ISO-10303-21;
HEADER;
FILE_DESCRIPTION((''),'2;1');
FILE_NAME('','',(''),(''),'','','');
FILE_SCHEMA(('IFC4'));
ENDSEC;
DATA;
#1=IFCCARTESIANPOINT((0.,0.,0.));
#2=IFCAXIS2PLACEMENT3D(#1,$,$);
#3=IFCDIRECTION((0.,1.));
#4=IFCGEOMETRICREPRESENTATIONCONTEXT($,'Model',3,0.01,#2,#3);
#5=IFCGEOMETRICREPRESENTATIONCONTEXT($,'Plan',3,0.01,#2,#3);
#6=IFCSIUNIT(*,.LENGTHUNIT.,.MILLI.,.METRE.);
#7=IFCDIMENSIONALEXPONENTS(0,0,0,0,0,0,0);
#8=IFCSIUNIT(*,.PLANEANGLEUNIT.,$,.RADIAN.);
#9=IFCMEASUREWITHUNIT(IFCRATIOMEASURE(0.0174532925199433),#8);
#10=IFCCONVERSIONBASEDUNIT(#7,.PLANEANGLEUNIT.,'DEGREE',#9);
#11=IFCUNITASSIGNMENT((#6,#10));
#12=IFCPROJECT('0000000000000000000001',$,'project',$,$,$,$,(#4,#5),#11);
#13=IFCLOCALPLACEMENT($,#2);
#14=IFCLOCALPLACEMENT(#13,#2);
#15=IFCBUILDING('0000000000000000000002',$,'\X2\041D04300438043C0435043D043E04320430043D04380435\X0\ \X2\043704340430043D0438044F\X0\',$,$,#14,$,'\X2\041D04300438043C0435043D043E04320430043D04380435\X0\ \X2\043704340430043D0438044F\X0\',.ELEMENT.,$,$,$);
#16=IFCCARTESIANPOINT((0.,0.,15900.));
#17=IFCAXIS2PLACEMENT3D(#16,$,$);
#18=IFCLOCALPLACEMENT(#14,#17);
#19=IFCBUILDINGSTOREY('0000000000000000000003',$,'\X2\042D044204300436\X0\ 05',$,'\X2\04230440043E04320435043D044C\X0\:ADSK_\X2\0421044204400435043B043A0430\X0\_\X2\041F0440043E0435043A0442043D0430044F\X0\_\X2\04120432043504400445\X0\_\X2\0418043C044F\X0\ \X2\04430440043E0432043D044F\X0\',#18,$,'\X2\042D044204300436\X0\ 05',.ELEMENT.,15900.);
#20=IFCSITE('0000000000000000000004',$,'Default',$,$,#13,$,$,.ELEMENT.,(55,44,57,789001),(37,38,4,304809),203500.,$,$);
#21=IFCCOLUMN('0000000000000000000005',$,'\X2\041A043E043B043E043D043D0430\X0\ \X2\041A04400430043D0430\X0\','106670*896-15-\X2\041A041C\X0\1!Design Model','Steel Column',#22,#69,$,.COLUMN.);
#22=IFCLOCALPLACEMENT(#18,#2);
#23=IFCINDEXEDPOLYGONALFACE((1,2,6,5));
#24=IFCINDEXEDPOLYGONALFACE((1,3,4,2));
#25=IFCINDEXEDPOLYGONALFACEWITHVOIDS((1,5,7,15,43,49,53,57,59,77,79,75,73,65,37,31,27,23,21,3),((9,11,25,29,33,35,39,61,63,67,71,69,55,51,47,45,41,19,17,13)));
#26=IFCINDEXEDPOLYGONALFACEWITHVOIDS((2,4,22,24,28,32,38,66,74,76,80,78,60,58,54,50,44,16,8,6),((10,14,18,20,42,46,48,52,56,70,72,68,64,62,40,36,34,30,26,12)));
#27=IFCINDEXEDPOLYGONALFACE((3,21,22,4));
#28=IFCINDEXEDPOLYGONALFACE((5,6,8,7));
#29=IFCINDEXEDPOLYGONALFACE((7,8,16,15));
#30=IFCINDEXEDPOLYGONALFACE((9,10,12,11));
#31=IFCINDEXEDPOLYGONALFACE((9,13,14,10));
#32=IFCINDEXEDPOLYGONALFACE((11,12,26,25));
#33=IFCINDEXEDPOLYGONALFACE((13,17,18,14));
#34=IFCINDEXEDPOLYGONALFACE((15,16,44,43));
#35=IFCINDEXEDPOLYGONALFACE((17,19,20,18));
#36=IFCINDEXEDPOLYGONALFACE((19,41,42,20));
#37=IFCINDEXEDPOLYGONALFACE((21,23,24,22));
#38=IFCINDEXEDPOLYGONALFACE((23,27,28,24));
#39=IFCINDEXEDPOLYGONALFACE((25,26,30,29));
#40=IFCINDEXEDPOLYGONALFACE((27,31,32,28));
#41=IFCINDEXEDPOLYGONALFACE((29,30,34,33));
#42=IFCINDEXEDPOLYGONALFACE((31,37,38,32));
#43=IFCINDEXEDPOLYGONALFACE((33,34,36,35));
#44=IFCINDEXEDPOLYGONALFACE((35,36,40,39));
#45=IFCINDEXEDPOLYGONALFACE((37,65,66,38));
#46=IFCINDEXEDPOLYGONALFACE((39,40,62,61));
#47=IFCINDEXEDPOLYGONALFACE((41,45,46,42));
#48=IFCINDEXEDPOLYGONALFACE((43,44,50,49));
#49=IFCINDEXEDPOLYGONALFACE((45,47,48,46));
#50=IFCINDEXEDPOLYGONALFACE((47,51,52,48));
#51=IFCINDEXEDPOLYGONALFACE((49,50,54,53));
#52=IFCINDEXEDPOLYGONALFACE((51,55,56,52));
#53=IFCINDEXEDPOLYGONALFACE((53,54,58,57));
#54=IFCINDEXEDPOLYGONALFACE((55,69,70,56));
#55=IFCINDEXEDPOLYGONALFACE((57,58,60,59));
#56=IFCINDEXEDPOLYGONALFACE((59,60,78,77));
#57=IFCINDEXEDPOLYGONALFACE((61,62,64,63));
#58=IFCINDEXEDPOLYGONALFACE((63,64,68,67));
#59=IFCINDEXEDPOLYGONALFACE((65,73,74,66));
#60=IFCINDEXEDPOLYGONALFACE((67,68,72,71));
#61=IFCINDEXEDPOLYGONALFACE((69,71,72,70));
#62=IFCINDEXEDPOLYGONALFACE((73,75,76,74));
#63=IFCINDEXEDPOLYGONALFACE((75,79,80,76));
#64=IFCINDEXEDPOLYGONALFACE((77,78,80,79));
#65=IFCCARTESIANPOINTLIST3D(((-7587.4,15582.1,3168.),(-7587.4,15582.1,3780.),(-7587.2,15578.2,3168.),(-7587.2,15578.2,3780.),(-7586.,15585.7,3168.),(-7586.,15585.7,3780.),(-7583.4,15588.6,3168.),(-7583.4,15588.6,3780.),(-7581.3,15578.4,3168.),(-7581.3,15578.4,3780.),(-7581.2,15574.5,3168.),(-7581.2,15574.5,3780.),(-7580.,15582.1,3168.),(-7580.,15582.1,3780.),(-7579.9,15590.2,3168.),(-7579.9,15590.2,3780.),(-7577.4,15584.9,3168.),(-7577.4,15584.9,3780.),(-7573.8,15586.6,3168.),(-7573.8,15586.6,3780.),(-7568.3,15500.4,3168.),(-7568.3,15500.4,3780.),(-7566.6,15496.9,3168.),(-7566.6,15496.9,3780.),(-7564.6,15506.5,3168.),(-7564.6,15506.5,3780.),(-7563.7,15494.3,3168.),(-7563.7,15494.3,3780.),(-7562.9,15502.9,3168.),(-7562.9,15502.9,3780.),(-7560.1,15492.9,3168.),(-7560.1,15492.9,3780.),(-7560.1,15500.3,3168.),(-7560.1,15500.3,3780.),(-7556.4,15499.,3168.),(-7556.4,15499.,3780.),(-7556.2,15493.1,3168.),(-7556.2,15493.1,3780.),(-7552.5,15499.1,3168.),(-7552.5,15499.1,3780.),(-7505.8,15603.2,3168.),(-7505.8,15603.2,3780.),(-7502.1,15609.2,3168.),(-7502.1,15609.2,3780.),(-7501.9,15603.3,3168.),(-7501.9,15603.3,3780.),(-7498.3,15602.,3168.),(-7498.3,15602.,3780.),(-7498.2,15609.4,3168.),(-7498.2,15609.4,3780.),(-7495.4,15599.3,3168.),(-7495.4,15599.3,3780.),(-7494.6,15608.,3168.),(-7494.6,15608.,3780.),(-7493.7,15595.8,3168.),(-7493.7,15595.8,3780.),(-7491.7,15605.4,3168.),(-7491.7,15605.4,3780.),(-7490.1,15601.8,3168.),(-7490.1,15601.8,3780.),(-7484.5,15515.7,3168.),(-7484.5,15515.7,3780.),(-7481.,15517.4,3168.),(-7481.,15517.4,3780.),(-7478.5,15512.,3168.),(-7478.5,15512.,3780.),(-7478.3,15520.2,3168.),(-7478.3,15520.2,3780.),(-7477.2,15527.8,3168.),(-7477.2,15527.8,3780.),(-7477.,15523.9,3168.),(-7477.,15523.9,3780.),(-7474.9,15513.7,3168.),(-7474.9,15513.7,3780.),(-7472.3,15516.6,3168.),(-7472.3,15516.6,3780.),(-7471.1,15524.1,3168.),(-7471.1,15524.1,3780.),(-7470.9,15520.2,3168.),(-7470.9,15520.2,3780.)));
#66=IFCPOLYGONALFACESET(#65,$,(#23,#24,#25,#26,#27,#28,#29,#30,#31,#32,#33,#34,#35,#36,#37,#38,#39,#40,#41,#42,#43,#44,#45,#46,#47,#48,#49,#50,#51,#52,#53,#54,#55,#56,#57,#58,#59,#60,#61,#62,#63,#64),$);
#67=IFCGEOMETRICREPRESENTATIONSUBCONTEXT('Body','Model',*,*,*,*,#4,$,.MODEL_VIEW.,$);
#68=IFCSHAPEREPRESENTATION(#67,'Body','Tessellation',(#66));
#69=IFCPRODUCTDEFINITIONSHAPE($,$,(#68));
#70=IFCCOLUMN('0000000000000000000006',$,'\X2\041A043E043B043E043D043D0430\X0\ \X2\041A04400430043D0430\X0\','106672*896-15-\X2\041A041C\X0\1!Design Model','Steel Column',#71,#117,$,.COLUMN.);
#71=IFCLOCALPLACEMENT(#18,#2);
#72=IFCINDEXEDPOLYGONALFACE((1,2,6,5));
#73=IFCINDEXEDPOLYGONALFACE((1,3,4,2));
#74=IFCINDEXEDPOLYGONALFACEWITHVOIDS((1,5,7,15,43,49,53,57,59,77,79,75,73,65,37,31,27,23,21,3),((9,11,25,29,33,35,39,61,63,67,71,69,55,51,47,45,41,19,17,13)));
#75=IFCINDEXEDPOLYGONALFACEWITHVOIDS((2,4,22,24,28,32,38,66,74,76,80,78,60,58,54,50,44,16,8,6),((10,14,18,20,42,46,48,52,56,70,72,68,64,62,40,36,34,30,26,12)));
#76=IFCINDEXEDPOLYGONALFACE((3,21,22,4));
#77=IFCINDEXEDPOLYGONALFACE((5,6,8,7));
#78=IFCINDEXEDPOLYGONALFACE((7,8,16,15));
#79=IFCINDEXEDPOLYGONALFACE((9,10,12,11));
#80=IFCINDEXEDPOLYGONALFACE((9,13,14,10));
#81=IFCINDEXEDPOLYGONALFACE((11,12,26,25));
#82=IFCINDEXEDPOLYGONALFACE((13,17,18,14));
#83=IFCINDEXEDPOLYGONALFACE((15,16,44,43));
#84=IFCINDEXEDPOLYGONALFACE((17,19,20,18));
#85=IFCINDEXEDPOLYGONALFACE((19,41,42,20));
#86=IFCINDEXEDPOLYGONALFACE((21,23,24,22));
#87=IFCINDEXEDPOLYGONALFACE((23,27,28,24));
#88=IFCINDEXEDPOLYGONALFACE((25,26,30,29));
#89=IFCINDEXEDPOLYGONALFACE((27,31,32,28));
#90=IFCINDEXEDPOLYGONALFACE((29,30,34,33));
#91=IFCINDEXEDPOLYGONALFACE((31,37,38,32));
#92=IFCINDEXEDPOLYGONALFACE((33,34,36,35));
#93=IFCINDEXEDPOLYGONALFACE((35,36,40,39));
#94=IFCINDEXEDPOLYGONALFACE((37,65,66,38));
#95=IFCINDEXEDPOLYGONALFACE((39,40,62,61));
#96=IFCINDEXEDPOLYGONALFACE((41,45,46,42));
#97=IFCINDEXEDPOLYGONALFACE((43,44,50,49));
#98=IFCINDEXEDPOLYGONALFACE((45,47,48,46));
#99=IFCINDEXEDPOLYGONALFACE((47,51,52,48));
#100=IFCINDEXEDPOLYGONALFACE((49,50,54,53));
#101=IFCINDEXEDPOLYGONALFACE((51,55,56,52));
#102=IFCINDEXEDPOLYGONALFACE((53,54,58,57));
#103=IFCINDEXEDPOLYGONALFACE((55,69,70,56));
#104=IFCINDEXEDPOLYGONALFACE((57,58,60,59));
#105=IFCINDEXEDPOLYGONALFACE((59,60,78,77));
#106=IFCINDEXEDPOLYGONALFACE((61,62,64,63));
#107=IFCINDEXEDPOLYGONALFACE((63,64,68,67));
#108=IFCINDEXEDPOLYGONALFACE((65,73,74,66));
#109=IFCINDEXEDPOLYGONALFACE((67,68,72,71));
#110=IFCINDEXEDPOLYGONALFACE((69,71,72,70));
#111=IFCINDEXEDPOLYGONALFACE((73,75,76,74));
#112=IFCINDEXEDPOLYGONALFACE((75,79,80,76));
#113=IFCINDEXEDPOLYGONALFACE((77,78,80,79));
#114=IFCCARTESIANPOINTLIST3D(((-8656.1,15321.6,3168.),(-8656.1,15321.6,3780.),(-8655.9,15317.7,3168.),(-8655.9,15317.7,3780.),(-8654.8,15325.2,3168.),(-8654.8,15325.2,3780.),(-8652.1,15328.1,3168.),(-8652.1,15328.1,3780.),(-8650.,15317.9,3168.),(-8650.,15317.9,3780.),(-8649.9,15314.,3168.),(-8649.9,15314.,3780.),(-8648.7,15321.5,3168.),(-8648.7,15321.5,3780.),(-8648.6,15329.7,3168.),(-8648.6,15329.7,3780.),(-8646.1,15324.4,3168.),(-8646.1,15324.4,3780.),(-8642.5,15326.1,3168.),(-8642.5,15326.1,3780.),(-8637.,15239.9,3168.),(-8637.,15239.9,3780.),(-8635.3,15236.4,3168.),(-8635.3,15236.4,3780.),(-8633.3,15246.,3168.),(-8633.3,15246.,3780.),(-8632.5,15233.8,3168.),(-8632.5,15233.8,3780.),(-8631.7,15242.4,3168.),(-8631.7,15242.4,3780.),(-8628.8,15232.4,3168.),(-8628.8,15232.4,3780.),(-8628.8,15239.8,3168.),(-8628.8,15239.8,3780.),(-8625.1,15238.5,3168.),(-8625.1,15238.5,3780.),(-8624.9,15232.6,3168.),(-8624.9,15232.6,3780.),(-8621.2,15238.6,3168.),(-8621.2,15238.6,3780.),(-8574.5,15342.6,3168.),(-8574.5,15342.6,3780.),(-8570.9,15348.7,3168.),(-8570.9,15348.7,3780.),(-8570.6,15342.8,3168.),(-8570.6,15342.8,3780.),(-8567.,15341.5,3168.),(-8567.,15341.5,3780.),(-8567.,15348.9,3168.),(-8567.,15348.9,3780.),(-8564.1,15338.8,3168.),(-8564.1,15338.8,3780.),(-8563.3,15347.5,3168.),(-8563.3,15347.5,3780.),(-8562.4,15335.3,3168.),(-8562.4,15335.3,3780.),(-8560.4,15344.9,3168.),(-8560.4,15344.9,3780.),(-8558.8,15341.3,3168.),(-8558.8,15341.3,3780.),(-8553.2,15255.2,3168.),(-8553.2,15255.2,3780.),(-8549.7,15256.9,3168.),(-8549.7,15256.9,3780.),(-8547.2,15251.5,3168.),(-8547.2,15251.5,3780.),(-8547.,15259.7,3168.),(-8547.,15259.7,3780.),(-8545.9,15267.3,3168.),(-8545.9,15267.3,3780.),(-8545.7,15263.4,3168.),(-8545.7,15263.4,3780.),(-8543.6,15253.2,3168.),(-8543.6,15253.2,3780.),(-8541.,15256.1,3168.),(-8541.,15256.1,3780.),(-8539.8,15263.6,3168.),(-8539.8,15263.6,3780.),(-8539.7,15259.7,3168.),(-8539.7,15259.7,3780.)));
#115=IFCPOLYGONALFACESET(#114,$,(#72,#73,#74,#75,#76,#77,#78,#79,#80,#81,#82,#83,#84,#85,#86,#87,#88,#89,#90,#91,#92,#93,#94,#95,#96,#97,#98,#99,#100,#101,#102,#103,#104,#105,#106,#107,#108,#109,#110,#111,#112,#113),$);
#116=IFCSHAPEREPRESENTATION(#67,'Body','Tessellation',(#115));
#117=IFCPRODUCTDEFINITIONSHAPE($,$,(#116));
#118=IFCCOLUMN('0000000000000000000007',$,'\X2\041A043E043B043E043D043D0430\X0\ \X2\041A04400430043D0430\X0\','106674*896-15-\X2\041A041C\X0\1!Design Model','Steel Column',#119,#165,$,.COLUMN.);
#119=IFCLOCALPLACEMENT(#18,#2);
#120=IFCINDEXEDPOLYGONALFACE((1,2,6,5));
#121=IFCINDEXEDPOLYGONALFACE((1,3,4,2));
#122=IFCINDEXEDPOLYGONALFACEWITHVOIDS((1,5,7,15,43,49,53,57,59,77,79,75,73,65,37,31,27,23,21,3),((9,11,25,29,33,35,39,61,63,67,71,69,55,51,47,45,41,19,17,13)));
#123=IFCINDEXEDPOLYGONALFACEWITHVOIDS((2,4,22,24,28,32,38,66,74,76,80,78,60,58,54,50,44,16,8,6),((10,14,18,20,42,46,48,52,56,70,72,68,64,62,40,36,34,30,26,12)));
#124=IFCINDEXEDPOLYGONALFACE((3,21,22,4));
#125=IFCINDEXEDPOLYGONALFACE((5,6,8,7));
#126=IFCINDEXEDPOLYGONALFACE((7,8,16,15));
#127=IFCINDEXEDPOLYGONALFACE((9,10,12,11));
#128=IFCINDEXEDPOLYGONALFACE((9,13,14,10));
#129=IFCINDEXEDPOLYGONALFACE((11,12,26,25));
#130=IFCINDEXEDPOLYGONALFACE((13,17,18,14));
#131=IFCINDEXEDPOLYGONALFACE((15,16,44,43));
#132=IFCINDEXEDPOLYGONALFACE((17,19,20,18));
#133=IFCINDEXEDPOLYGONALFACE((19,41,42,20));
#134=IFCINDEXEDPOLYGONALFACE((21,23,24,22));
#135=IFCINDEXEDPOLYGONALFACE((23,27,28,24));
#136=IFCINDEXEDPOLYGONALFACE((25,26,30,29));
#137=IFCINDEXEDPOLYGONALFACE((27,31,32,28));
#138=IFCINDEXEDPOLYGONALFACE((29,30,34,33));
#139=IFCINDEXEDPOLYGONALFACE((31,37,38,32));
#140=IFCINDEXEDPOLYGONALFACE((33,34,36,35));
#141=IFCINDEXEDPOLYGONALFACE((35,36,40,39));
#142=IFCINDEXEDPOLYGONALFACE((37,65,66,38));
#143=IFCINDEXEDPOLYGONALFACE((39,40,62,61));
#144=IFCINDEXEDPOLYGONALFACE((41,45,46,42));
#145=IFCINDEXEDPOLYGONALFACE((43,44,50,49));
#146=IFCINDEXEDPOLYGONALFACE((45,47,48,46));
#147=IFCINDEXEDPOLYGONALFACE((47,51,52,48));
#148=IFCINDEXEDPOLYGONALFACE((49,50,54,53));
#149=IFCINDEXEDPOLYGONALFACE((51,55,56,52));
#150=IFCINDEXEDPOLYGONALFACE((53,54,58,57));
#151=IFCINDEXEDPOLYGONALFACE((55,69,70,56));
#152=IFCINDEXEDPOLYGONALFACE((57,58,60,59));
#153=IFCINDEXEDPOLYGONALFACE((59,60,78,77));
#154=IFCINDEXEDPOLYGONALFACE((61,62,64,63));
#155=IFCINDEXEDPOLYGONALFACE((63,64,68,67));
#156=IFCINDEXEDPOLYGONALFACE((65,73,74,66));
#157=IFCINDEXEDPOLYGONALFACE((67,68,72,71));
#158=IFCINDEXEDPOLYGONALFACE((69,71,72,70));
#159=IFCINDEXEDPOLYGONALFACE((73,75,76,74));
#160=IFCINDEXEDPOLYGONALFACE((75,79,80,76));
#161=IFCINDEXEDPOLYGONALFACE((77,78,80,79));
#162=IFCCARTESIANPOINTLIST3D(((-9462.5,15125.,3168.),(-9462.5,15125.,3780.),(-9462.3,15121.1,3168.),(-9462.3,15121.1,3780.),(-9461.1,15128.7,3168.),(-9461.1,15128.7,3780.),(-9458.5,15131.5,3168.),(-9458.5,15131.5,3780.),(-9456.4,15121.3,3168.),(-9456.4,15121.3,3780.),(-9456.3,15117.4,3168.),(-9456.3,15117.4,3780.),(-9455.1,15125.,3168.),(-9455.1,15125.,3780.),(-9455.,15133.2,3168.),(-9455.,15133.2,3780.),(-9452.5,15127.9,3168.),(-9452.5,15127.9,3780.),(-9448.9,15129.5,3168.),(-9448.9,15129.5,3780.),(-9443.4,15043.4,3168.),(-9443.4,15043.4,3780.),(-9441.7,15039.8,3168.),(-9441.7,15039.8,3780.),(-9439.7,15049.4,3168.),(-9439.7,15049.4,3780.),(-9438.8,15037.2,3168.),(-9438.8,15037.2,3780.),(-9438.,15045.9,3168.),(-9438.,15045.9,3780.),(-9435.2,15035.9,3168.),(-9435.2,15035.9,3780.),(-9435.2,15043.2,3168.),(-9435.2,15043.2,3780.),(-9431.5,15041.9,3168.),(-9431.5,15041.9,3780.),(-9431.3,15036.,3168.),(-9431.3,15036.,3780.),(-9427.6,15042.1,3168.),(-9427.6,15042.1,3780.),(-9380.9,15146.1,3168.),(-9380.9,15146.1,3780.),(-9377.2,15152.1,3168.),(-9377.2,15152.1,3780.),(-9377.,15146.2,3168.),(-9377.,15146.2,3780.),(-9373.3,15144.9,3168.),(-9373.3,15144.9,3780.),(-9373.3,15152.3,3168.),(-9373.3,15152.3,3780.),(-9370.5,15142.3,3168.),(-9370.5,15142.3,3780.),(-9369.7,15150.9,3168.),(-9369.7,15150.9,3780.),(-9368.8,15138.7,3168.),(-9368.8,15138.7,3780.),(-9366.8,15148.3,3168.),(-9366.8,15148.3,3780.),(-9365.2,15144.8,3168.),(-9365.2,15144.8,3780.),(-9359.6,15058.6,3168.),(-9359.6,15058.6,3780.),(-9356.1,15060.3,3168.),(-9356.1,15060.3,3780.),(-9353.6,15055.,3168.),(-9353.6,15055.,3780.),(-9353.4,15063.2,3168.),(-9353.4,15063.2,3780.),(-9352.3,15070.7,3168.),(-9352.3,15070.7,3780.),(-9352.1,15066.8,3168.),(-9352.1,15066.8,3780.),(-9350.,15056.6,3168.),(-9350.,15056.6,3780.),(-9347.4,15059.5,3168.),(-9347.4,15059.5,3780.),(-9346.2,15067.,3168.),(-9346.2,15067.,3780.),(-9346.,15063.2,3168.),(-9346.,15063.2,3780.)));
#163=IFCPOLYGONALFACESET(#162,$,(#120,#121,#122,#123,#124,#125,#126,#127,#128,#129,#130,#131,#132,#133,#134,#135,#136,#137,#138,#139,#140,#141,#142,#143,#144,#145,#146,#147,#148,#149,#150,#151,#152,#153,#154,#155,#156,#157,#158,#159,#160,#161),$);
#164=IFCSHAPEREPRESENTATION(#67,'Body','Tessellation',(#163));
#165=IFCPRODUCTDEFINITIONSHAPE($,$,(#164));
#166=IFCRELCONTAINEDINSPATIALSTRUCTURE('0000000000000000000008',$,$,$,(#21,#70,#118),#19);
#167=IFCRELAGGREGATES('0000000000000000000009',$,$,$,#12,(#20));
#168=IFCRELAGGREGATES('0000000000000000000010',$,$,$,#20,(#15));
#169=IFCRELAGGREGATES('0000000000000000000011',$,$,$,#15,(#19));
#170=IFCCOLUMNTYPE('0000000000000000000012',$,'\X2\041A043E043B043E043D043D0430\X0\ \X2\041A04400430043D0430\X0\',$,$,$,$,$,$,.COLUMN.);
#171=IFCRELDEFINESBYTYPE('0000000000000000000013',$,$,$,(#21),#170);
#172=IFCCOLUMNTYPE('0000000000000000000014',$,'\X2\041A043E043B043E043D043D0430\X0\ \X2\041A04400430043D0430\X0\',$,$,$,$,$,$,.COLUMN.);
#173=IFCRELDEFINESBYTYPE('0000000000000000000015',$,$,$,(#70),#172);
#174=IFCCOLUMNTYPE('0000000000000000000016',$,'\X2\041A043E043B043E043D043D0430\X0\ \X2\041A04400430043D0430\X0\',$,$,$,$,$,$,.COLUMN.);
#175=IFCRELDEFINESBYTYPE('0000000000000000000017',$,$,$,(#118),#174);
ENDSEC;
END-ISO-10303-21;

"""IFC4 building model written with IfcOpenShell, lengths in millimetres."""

from ifc_helpers import new_model, entity, si_unit, converted_unit, direction, frame, origin, place, context, subcontext, project, spatial, indexed_curve, outline, extrude, type_object, element, save


model = new_model("IFC4")

# Units and contexts
model_context = context("Model", 3, precision=0.01, world=origin(), true_north=direction((0.0, 1.0)))
plan_context = context("Plan", 3, precision=0.01, world=origin(), true_north=direction((0.0, 1.0)))
body_context = subcontext(model_context, "Body", "Model", "MODEL_VIEW")
ifc_project = project(units=[si_unit("LENGTHUNIT", "METRE", prefix="MILLI"), converted_unit("PLANEANGLEUNIT", "DEGREE", entity("IfcRatioMeasure", 0.0174532925199433), si_unit("PLANEANGLEUNIT", "RADIAN"), dimensions=[0, 0, 0, 0, 0, 0, 0])], contexts=[model_context, plan_context])

# Site, building, storey
site_placement = place(None, origin())
site = spatial("IfcSite", under=ifc_project, at=site_placement, Name="Default", CompositionType="ELEMENT", RefLatitude=(55, 44, 57, 789001), RefLongitude=(37, 38, 4, 304809), RefElevation=203500.0)
building_placement = place(site_placement, origin())
building = spatial("IfcBuilding", under=site, at=building_placement, Name="Наименование здания", LongName="Наименование здания", CompositionType="ELEMENT")
storey_placement = place(building_placement, frame((0.0, 0.0, 15900.0)))
storey = spatial("IfcBuildingStorey", under=building, at=storey_placement, Name="Этаж 05", ObjectType="Уровень:ADSK_Стрелка_Проектная_Вверх_Имя уровня", LongName="Этаж 05", CompositionType="ELEMENT", Elevation=15900.0)

# Columns
column_type_1 = type_object("IfcColumnType", Name="Колонна Крана", PredefinedType="COLUMN")
column_1_placement = place(storey_placement, origin())
element("IfcColumn", 1, at=column_1_placement, inside=storey, type_object=column_type_1, Name="Колонна Крана", Description="106670*896-15-КМ1!Design Model", ObjectType="Steel Column", PredefinedType="COLUMN", context=body_context, shape_type="SweptSolid", body=[
    extrude(outline(indexed_curve([(29.5, -56.8), (33.4, -56.8), (37.0, -55.3), (39.7, -52.6), (41.2, -49.0), (56.8, 29.5), (56.8, 33.4), (55.3, 37.0), (52.6, 39.7), (49.0, 41.2), (-29.5, 56.8), (-33.4, 56.8), (-37.0, 55.3), (-39.7, 52.6), (-41.2, 49.0), (-56.8, -29.5), (-56.8, -33.4), (-55.3, -37.0), (-52.6, -39.7), (-49.0, -41.2), (29.5, -56.8)], self_intersect=False), holes=[indexed_curve([(-43.1, -37.3), (-46.7, -35.8), (-49.5, -33.1), (-51.0, -29.5), (-51.0, -25.5), (-37.3, 43.1), (-35.8, 46.7), (-33.1, 49.5), (-29.5, 51.0), (-25.5, 51.0), (43.1, 37.3), (46.7, 35.8), (49.5, 33.1), (51.0, 29.5), (51.0, 25.5), (37.3, -43.1), (35.8, -46.7), (33.1, -49.5), (29.5, -51.0), (25.5, -51.0), (-43.1, -37.3)], self_intersect=False)]), frame((-7529.2, 15551.1, 3168.0), z_axis=(0.0, 0.0, 1.0), x_axis=(-0.906681, -0.421816, 0.0)), (0.0, 0.0, 1.0), 612.0),
])
column_type_2 = type_object("IfcColumnType", Name="Колонна Крана", PredefinedType="COLUMN")
column_2_placement = place(storey_placement, origin())
element("IfcColumn", 2, at=column_2_placement, inside=storey, type_object=column_type_2, Name="Колонна Крана", Description="106672*896-15-КМ1!Design Model", ObjectType="Steel Column", PredefinedType="COLUMN", context=body_context, shape_type="SweptSolid", body=[
    extrude(outline(indexed_curve([(29.5, -56.8), (33.4, -56.8), (37.0, -55.3), (39.7, -52.6), (41.2, -49.0), (56.8, 29.5), (56.8, 33.4), (55.3, 37.0), (52.6, 39.7), (49.0, 41.2), (-29.5, 56.8), (-33.4, 56.8), (-37.0, 55.3), (-39.7, 52.6), (-41.2, 49.0), (-56.8, -29.5), (-56.8, -33.4), (-55.3, -37.0), (-52.6, -39.7), (-49.0, -41.2), (29.5, -56.8)], self_intersect=False), holes=[indexed_curve([(-43.1, -37.3), (-46.7, -35.8), (-49.5, -33.1), (-51.0, -29.5), (-51.0, -25.5), (-37.3, 43.1), (-35.8, 46.7), (-33.1, 49.5), (-29.5, 51.0), (-25.5, 51.0), (43.1, 37.3), (46.7, 35.8), (49.5, 33.1), (51.0, 29.5), (51.0, 25.5), (37.3, -43.1), (35.8, -46.7), (33.1, -49.5), (29.5, -51.0), (25.5, -51.0), (-43.1, -37.3)], self_intersect=False)]), frame((-8597.9, 15290.6, 3168.0), z_axis=(0.0, 0.0, 1.0), x_axis=(-0.906681, -0.421816, 0.0)), (0.0, 0.0, 1.0), 612.0),
])
column_type_3 = type_object("IfcColumnType", Name="Колонна Крана", PredefinedType="COLUMN")
column_3_placement = place(storey_placement, origin())
element("IfcColumn", 3, at=column_3_placement, inside=storey, type_object=column_type_3, Name="Колонна Крана", Description="106674*896-15-КМ1!Design Model", ObjectType="Steel Column", PredefinedType="COLUMN", context=body_context, shape_type="SweptSolid", body=[
    extrude(outline(indexed_curve([(29.5, -56.8), (33.4, -56.8), (37.0, -55.3), (39.7, -52.6), (41.2, -49.0), (56.8, 29.5), (56.8, 33.4), (55.3, 37.0), (52.6, 39.7), (49.0, 41.2), (-29.5, 56.8), (-33.4, 56.8), (-37.0, 55.3), (-39.7, 52.6), (-41.2, 49.0), (-56.8, -29.5), (-56.8, -33.4), (-55.3, -37.0), (-52.6, -39.7), (-49.0, -41.2), (29.5, -56.8)], self_intersect=False), holes=[indexed_curve([(-43.1, -37.3), (-46.7, -35.8), (-49.5, -33.1), (-51.0, -29.5), (-51.0, -25.5), (-37.3, 43.1), (-35.8, 46.7), (-33.1, 49.5), (-29.5, 51.0), (-25.5, 51.0), (43.1, 37.3), (46.7, 35.8), (49.5, 33.1), (51.0, 29.5), (51.0, 25.5), (37.3, -43.1), (35.8, -46.7), (33.1, -49.5), (29.5, -51.0), (25.5, -51.0), (-43.1, -37.3)], self_intersect=False)]), frame((-9404.3, 15094.1, 3168.0), z_axis=(0.0, 0.0, 1.0), x_axis=(-0.906681, -0.421816, 0.0)), (0.0, 0.0, 1.0), 612.0),
])

save(model, "model.ifc")
